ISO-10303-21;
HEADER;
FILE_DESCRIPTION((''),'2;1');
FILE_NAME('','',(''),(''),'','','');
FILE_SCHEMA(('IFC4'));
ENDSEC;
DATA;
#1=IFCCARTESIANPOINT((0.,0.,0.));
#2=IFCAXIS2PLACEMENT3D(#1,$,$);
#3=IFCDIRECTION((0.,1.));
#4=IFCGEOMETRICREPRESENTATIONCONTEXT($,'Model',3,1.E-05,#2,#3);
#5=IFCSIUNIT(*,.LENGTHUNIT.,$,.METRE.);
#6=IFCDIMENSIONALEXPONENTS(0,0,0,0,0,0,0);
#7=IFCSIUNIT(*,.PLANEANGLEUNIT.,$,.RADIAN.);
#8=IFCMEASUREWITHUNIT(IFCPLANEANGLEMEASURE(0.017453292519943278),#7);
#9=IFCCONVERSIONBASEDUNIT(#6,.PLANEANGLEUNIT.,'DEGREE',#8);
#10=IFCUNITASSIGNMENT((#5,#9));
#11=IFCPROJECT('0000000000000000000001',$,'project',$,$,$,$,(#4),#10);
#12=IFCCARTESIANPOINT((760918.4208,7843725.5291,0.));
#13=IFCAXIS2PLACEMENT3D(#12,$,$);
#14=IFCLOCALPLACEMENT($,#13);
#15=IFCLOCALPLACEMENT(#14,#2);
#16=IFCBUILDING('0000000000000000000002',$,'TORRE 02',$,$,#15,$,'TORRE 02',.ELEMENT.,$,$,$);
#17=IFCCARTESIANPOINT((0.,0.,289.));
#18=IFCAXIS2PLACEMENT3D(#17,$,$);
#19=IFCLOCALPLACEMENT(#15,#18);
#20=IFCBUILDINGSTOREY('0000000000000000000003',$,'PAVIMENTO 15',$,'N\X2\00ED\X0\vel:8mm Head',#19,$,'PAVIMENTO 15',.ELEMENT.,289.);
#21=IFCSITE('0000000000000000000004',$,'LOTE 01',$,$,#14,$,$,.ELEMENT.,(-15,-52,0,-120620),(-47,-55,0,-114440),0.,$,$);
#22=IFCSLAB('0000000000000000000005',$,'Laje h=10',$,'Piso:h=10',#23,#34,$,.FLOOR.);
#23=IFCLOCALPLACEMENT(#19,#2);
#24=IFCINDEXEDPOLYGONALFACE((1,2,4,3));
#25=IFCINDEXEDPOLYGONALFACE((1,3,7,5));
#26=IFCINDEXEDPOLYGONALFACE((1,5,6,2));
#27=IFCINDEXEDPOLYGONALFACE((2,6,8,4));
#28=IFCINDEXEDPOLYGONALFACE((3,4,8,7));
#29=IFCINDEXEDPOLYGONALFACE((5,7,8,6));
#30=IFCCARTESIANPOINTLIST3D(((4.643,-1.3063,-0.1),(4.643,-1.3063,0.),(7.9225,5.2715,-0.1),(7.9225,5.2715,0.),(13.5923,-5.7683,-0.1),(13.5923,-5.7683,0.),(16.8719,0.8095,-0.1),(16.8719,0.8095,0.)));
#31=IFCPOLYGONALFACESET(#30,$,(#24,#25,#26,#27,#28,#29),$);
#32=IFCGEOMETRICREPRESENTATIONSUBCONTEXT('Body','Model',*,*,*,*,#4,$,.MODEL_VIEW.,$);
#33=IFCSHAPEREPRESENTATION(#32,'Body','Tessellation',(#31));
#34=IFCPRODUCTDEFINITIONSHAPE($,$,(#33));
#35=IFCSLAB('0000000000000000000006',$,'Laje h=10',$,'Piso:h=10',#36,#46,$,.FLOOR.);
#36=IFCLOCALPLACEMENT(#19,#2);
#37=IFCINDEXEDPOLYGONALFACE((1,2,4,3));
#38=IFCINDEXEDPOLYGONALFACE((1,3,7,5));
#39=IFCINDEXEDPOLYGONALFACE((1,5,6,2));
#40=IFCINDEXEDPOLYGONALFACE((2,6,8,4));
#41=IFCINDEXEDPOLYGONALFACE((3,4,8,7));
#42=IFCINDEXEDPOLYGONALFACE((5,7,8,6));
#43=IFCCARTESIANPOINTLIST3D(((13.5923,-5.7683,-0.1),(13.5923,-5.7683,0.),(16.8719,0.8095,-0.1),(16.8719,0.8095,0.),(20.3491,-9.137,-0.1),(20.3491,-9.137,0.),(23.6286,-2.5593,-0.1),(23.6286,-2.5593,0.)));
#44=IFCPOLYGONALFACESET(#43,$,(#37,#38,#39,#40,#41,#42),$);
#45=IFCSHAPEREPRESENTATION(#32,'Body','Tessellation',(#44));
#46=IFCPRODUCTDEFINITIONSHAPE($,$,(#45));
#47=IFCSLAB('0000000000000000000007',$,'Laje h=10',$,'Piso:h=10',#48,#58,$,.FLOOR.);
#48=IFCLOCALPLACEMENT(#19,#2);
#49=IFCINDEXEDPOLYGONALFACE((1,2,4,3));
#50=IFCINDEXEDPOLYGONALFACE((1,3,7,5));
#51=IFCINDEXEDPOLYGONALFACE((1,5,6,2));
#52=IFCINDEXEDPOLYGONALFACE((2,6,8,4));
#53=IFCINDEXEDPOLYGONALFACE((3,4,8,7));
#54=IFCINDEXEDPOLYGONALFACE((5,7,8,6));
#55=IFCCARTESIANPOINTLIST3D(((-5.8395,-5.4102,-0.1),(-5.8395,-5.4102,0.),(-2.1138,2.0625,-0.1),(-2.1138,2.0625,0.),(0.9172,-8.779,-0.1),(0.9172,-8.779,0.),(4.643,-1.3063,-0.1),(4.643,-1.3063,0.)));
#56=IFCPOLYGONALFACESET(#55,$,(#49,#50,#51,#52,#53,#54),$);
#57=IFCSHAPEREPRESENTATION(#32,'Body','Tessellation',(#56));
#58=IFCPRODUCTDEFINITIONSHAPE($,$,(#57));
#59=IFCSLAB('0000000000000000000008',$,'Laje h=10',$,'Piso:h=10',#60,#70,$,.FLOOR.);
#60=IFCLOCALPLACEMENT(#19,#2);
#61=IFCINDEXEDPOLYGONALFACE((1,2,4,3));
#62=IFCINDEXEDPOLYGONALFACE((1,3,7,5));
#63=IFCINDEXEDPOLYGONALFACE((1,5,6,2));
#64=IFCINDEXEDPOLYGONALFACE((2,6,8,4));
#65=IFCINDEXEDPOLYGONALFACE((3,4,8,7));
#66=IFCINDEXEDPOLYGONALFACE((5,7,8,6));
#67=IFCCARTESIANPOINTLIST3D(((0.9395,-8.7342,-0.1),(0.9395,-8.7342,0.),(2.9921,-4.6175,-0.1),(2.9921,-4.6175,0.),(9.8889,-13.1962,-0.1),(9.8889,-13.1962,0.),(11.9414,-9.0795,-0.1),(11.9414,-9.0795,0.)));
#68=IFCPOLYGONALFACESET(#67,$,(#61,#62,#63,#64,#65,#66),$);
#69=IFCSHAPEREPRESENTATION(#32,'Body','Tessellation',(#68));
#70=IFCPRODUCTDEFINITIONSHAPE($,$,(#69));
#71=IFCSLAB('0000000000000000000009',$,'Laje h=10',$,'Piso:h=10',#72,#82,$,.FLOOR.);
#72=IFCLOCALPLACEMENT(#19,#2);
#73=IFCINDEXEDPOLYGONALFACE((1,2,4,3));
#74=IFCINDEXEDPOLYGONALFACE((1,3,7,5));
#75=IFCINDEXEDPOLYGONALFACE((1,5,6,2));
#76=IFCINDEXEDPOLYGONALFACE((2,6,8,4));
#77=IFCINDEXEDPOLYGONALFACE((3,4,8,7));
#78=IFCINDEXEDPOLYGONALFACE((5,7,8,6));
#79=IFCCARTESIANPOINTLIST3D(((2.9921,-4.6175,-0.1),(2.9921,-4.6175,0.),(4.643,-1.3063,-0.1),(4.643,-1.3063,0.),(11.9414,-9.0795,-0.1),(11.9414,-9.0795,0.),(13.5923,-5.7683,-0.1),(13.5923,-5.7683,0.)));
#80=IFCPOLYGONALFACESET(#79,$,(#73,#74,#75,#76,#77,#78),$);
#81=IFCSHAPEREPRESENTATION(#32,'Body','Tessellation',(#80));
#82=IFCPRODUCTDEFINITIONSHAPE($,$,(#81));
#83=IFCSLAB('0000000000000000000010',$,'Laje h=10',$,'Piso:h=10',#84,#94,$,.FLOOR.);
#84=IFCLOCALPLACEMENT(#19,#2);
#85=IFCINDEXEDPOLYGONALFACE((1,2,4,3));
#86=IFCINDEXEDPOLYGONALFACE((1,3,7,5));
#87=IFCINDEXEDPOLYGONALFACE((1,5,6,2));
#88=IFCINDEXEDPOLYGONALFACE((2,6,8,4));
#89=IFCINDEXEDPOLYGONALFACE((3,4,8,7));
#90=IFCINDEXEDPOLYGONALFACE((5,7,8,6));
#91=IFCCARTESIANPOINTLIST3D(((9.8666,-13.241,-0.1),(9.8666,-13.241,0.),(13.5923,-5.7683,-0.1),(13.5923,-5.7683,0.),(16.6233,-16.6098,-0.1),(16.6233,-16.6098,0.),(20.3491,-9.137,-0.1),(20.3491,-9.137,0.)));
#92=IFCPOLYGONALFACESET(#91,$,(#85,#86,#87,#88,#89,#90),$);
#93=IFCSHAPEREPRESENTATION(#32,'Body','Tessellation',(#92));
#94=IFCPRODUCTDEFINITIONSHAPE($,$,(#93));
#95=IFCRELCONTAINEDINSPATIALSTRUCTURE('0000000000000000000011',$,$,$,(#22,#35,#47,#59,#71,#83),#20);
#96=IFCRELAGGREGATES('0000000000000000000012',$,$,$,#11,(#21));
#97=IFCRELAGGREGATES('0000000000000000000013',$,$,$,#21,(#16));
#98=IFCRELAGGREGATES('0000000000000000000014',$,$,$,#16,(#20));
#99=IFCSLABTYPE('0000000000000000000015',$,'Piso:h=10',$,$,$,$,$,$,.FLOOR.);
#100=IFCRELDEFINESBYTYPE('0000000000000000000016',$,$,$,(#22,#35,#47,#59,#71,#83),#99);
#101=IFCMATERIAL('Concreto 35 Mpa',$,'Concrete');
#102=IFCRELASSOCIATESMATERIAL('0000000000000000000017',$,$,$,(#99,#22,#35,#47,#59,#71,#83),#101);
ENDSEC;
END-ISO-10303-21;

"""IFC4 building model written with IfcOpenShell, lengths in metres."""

from ifc_helpers import new_model, entity, si_unit, converted_unit, direction, frame, origin, place, context, subcontext, project, spatial, indexed_curve, outline, extrude, material, type_object, element, save


model = new_model("IFC4")

# Units and contexts
model_context = context("Model", 3, precision=1e-05, world=origin(), true_north=direction((0.0, 1.0)))
body_context = subcontext(model_context, "Body", "Model", "MODEL_VIEW")
ifc_project = project(units=[si_unit("LENGTHUNIT", "METRE"), converted_unit("PLANEANGLEUNIT", "DEGREE", entity("IfcPlaneAngleMeasure", 0.017453292519943278), si_unit("PLANEANGLEUNIT", "RADIAN"), dimensions=[0, 0, 0, 0, 0, 0, 0])], contexts=[model_context])

# Site, building, storey
site_placement = place(None, frame((760918.4208, 7843725.5291, 0.0)))
site = spatial("IfcSite", under=ifc_project, at=site_placement, Name="LOTE 01", CompositionType="ELEMENT", RefLatitude=(-15, -52, 0, -120620), RefLongitude=(-47, -55, 0, -114440), RefElevation=0.0)
building_placement = place(site_placement, origin())
building = spatial("IfcBuilding", under=site, at=building_placement, Name="TORRE 02", LongName="TORRE 02", CompositionType="ELEMENT")
storey_placement = place(building_placement, frame((0.0, 0.0, 289.0)))
storey = spatial("IfcBuildingStorey", under=building, at=storey_placement, Name="PAVIMENTO 15", ObjectType="Nível:8mm Head", LongName="PAVIMENTO 15", CompositionType="ELEMENT", Elevation=289.0)

# Slabs
ifc_material_1 = material(Name="Concreto 35 Mpa", Category="Concrete")
slab_type = type_object("IfcSlabType", Name="Piso:h=10", PredefinedType="FLOOR", material=ifc_material_1)
slab_1_placement = place(storey_placement, origin())
element("IfcSlab", 1, at=slab_1_placement, inside=storey, type_object=slab_type, material=ifc_material_1, Name="Laje h=10", ObjectType="Piso:h=10", PredefinedType="FLOOR", context=body_context, shape_type="SweptSolid", body=[
    extrude(outline(indexed_curve([(-3.675, -5.0), (3.675, -5.0), (3.675, 5.0), (-3.675, 5.0), (-3.675, -5.0)], self_intersect=False)), frame((10.7574, -0.2484, 0.0), z_axis=(0.0, 0.0, -1.0), x_axis=(-0.446198, -0.894934, 0.0)), (0.0, 0.0, 1.0), 0.1),
])
slab_2_placement = place(storey_placement, origin())
element("IfcSlab", 2, at=slab_2_placement, inside=storey, type_object=slab_type, material=ifc_material_1, Name="Laje h=10", ObjectType="Piso:h=10", PredefinedType="FLOOR", context=body_context, shape_type="SweptSolid", body=[
    extrude(outline(indexed_curve([(-3.675, -3.775), (3.675, -3.775), (3.675, 3.775), (-3.675, 3.775), (-3.675, -3.775)], self_intersect=False)), frame((18.6105, -4.1638, 0.0), z_axis=(0.0, 0.0, -1.0), x_axis=(-0.446198, -0.894934, 0.0)), (0.0, 0.0, 1.0), 0.1),
])
slab_3_placement = place(storey_placement, origin())
element("IfcSlab", 3, at=slab_3_placement, inside=storey, type_object=slab_type, material=ifc_material_1, Name="Laje h=10", ObjectType="Piso:h=10", PredefinedType="FLOOR", context=body_context, shape_type="SweptSolid", body=[
    extrude(outline(indexed_curve([(-4.175, -3.775), (4.175, -3.775), (4.175, 3.775), (-4.175, 3.775), (-4.175, -3.775)], self_intersect=False)), frame((-0.5983, -3.3582, 0.0), z_axis=(0.0, 0.0, -1.0), x_axis=(-0.446198, -0.894934, 0.0)), (0.0, 0.0, 1.0), 0.1),
])
slab_4_placement = place(storey_placement, origin())
element("IfcSlab", 4, at=slab_4_placement, inside=storey, type_object=slab_type, material=ifc_material_1, Name="Laje h=10", ObjectType="Piso:h=10", PredefinedType="FLOOR", context=body_context, shape_type="SweptSolid", body=[
    extrude(outline(indexed_curve([(-2.3, -5.0), (2.3, -5.0), (2.3, 5.0), (-2.3, 5.0), (-2.3, -5.0)], self_intersect=False)), frame((6.4405, -8.9069, 0.0), z_axis=(0.0, 0.0, -1.0), x_axis=(-0.446198, -0.894934, 0.0)), (0.0, 0.0, 1.0), 0.1),
])
slab_5_placement = place(storey_placement, origin())
element("IfcSlab", 5, at=slab_5_placement, inside=storey, type_object=slab_type, material=ifc_material_1, Name="Laje h=10", ObjectType="Piso:h=10", PredefinedType="FLOOR", context=body_context, shape_type="SweptSolid", body=[
    extrude(outline(indexed_curve([(-1.85, -5.0), (1.85, -5.0), (1.85, 5.0), (-1.85, 5.0), (-1.85, -5.0)], self_intersect=False)), frame((8.2922, -5.1929, 0.0), z_axis=(0.0, 0.0, -1.0), x_axis=(-0.446198, -0.894934, 0.0)), (0.0, 0.0, 1.0), 0.1),
])
slab_6_placement = place(storey_placement, origin())
element("IfcSlab", 6, at=slab_6_placement, inside=storey, type_object=slab_type, material=ifc_material_1, Name="Laje h=10", ObjectType="Piso:h=10", PredefinedType="FLOOR", context=body_context, shape_type="SweptSolid", body=[
    extrude(outline(indexed_curve([(-4.175, -3.775), (4.175, -3.775), (4.175, 3.775), (-4.175, 3.775), (-4.175, -3.775)], self_intersect=False)), frame((15.1078, -11.189, 0.0), z_axis=(0.0, 0.0, -1.0), x_axis=(-0.446198, -0.894934, 0.0)), (0.0, 0.0, 1.0), 0.1),
])

save(model, "model.ifc")
